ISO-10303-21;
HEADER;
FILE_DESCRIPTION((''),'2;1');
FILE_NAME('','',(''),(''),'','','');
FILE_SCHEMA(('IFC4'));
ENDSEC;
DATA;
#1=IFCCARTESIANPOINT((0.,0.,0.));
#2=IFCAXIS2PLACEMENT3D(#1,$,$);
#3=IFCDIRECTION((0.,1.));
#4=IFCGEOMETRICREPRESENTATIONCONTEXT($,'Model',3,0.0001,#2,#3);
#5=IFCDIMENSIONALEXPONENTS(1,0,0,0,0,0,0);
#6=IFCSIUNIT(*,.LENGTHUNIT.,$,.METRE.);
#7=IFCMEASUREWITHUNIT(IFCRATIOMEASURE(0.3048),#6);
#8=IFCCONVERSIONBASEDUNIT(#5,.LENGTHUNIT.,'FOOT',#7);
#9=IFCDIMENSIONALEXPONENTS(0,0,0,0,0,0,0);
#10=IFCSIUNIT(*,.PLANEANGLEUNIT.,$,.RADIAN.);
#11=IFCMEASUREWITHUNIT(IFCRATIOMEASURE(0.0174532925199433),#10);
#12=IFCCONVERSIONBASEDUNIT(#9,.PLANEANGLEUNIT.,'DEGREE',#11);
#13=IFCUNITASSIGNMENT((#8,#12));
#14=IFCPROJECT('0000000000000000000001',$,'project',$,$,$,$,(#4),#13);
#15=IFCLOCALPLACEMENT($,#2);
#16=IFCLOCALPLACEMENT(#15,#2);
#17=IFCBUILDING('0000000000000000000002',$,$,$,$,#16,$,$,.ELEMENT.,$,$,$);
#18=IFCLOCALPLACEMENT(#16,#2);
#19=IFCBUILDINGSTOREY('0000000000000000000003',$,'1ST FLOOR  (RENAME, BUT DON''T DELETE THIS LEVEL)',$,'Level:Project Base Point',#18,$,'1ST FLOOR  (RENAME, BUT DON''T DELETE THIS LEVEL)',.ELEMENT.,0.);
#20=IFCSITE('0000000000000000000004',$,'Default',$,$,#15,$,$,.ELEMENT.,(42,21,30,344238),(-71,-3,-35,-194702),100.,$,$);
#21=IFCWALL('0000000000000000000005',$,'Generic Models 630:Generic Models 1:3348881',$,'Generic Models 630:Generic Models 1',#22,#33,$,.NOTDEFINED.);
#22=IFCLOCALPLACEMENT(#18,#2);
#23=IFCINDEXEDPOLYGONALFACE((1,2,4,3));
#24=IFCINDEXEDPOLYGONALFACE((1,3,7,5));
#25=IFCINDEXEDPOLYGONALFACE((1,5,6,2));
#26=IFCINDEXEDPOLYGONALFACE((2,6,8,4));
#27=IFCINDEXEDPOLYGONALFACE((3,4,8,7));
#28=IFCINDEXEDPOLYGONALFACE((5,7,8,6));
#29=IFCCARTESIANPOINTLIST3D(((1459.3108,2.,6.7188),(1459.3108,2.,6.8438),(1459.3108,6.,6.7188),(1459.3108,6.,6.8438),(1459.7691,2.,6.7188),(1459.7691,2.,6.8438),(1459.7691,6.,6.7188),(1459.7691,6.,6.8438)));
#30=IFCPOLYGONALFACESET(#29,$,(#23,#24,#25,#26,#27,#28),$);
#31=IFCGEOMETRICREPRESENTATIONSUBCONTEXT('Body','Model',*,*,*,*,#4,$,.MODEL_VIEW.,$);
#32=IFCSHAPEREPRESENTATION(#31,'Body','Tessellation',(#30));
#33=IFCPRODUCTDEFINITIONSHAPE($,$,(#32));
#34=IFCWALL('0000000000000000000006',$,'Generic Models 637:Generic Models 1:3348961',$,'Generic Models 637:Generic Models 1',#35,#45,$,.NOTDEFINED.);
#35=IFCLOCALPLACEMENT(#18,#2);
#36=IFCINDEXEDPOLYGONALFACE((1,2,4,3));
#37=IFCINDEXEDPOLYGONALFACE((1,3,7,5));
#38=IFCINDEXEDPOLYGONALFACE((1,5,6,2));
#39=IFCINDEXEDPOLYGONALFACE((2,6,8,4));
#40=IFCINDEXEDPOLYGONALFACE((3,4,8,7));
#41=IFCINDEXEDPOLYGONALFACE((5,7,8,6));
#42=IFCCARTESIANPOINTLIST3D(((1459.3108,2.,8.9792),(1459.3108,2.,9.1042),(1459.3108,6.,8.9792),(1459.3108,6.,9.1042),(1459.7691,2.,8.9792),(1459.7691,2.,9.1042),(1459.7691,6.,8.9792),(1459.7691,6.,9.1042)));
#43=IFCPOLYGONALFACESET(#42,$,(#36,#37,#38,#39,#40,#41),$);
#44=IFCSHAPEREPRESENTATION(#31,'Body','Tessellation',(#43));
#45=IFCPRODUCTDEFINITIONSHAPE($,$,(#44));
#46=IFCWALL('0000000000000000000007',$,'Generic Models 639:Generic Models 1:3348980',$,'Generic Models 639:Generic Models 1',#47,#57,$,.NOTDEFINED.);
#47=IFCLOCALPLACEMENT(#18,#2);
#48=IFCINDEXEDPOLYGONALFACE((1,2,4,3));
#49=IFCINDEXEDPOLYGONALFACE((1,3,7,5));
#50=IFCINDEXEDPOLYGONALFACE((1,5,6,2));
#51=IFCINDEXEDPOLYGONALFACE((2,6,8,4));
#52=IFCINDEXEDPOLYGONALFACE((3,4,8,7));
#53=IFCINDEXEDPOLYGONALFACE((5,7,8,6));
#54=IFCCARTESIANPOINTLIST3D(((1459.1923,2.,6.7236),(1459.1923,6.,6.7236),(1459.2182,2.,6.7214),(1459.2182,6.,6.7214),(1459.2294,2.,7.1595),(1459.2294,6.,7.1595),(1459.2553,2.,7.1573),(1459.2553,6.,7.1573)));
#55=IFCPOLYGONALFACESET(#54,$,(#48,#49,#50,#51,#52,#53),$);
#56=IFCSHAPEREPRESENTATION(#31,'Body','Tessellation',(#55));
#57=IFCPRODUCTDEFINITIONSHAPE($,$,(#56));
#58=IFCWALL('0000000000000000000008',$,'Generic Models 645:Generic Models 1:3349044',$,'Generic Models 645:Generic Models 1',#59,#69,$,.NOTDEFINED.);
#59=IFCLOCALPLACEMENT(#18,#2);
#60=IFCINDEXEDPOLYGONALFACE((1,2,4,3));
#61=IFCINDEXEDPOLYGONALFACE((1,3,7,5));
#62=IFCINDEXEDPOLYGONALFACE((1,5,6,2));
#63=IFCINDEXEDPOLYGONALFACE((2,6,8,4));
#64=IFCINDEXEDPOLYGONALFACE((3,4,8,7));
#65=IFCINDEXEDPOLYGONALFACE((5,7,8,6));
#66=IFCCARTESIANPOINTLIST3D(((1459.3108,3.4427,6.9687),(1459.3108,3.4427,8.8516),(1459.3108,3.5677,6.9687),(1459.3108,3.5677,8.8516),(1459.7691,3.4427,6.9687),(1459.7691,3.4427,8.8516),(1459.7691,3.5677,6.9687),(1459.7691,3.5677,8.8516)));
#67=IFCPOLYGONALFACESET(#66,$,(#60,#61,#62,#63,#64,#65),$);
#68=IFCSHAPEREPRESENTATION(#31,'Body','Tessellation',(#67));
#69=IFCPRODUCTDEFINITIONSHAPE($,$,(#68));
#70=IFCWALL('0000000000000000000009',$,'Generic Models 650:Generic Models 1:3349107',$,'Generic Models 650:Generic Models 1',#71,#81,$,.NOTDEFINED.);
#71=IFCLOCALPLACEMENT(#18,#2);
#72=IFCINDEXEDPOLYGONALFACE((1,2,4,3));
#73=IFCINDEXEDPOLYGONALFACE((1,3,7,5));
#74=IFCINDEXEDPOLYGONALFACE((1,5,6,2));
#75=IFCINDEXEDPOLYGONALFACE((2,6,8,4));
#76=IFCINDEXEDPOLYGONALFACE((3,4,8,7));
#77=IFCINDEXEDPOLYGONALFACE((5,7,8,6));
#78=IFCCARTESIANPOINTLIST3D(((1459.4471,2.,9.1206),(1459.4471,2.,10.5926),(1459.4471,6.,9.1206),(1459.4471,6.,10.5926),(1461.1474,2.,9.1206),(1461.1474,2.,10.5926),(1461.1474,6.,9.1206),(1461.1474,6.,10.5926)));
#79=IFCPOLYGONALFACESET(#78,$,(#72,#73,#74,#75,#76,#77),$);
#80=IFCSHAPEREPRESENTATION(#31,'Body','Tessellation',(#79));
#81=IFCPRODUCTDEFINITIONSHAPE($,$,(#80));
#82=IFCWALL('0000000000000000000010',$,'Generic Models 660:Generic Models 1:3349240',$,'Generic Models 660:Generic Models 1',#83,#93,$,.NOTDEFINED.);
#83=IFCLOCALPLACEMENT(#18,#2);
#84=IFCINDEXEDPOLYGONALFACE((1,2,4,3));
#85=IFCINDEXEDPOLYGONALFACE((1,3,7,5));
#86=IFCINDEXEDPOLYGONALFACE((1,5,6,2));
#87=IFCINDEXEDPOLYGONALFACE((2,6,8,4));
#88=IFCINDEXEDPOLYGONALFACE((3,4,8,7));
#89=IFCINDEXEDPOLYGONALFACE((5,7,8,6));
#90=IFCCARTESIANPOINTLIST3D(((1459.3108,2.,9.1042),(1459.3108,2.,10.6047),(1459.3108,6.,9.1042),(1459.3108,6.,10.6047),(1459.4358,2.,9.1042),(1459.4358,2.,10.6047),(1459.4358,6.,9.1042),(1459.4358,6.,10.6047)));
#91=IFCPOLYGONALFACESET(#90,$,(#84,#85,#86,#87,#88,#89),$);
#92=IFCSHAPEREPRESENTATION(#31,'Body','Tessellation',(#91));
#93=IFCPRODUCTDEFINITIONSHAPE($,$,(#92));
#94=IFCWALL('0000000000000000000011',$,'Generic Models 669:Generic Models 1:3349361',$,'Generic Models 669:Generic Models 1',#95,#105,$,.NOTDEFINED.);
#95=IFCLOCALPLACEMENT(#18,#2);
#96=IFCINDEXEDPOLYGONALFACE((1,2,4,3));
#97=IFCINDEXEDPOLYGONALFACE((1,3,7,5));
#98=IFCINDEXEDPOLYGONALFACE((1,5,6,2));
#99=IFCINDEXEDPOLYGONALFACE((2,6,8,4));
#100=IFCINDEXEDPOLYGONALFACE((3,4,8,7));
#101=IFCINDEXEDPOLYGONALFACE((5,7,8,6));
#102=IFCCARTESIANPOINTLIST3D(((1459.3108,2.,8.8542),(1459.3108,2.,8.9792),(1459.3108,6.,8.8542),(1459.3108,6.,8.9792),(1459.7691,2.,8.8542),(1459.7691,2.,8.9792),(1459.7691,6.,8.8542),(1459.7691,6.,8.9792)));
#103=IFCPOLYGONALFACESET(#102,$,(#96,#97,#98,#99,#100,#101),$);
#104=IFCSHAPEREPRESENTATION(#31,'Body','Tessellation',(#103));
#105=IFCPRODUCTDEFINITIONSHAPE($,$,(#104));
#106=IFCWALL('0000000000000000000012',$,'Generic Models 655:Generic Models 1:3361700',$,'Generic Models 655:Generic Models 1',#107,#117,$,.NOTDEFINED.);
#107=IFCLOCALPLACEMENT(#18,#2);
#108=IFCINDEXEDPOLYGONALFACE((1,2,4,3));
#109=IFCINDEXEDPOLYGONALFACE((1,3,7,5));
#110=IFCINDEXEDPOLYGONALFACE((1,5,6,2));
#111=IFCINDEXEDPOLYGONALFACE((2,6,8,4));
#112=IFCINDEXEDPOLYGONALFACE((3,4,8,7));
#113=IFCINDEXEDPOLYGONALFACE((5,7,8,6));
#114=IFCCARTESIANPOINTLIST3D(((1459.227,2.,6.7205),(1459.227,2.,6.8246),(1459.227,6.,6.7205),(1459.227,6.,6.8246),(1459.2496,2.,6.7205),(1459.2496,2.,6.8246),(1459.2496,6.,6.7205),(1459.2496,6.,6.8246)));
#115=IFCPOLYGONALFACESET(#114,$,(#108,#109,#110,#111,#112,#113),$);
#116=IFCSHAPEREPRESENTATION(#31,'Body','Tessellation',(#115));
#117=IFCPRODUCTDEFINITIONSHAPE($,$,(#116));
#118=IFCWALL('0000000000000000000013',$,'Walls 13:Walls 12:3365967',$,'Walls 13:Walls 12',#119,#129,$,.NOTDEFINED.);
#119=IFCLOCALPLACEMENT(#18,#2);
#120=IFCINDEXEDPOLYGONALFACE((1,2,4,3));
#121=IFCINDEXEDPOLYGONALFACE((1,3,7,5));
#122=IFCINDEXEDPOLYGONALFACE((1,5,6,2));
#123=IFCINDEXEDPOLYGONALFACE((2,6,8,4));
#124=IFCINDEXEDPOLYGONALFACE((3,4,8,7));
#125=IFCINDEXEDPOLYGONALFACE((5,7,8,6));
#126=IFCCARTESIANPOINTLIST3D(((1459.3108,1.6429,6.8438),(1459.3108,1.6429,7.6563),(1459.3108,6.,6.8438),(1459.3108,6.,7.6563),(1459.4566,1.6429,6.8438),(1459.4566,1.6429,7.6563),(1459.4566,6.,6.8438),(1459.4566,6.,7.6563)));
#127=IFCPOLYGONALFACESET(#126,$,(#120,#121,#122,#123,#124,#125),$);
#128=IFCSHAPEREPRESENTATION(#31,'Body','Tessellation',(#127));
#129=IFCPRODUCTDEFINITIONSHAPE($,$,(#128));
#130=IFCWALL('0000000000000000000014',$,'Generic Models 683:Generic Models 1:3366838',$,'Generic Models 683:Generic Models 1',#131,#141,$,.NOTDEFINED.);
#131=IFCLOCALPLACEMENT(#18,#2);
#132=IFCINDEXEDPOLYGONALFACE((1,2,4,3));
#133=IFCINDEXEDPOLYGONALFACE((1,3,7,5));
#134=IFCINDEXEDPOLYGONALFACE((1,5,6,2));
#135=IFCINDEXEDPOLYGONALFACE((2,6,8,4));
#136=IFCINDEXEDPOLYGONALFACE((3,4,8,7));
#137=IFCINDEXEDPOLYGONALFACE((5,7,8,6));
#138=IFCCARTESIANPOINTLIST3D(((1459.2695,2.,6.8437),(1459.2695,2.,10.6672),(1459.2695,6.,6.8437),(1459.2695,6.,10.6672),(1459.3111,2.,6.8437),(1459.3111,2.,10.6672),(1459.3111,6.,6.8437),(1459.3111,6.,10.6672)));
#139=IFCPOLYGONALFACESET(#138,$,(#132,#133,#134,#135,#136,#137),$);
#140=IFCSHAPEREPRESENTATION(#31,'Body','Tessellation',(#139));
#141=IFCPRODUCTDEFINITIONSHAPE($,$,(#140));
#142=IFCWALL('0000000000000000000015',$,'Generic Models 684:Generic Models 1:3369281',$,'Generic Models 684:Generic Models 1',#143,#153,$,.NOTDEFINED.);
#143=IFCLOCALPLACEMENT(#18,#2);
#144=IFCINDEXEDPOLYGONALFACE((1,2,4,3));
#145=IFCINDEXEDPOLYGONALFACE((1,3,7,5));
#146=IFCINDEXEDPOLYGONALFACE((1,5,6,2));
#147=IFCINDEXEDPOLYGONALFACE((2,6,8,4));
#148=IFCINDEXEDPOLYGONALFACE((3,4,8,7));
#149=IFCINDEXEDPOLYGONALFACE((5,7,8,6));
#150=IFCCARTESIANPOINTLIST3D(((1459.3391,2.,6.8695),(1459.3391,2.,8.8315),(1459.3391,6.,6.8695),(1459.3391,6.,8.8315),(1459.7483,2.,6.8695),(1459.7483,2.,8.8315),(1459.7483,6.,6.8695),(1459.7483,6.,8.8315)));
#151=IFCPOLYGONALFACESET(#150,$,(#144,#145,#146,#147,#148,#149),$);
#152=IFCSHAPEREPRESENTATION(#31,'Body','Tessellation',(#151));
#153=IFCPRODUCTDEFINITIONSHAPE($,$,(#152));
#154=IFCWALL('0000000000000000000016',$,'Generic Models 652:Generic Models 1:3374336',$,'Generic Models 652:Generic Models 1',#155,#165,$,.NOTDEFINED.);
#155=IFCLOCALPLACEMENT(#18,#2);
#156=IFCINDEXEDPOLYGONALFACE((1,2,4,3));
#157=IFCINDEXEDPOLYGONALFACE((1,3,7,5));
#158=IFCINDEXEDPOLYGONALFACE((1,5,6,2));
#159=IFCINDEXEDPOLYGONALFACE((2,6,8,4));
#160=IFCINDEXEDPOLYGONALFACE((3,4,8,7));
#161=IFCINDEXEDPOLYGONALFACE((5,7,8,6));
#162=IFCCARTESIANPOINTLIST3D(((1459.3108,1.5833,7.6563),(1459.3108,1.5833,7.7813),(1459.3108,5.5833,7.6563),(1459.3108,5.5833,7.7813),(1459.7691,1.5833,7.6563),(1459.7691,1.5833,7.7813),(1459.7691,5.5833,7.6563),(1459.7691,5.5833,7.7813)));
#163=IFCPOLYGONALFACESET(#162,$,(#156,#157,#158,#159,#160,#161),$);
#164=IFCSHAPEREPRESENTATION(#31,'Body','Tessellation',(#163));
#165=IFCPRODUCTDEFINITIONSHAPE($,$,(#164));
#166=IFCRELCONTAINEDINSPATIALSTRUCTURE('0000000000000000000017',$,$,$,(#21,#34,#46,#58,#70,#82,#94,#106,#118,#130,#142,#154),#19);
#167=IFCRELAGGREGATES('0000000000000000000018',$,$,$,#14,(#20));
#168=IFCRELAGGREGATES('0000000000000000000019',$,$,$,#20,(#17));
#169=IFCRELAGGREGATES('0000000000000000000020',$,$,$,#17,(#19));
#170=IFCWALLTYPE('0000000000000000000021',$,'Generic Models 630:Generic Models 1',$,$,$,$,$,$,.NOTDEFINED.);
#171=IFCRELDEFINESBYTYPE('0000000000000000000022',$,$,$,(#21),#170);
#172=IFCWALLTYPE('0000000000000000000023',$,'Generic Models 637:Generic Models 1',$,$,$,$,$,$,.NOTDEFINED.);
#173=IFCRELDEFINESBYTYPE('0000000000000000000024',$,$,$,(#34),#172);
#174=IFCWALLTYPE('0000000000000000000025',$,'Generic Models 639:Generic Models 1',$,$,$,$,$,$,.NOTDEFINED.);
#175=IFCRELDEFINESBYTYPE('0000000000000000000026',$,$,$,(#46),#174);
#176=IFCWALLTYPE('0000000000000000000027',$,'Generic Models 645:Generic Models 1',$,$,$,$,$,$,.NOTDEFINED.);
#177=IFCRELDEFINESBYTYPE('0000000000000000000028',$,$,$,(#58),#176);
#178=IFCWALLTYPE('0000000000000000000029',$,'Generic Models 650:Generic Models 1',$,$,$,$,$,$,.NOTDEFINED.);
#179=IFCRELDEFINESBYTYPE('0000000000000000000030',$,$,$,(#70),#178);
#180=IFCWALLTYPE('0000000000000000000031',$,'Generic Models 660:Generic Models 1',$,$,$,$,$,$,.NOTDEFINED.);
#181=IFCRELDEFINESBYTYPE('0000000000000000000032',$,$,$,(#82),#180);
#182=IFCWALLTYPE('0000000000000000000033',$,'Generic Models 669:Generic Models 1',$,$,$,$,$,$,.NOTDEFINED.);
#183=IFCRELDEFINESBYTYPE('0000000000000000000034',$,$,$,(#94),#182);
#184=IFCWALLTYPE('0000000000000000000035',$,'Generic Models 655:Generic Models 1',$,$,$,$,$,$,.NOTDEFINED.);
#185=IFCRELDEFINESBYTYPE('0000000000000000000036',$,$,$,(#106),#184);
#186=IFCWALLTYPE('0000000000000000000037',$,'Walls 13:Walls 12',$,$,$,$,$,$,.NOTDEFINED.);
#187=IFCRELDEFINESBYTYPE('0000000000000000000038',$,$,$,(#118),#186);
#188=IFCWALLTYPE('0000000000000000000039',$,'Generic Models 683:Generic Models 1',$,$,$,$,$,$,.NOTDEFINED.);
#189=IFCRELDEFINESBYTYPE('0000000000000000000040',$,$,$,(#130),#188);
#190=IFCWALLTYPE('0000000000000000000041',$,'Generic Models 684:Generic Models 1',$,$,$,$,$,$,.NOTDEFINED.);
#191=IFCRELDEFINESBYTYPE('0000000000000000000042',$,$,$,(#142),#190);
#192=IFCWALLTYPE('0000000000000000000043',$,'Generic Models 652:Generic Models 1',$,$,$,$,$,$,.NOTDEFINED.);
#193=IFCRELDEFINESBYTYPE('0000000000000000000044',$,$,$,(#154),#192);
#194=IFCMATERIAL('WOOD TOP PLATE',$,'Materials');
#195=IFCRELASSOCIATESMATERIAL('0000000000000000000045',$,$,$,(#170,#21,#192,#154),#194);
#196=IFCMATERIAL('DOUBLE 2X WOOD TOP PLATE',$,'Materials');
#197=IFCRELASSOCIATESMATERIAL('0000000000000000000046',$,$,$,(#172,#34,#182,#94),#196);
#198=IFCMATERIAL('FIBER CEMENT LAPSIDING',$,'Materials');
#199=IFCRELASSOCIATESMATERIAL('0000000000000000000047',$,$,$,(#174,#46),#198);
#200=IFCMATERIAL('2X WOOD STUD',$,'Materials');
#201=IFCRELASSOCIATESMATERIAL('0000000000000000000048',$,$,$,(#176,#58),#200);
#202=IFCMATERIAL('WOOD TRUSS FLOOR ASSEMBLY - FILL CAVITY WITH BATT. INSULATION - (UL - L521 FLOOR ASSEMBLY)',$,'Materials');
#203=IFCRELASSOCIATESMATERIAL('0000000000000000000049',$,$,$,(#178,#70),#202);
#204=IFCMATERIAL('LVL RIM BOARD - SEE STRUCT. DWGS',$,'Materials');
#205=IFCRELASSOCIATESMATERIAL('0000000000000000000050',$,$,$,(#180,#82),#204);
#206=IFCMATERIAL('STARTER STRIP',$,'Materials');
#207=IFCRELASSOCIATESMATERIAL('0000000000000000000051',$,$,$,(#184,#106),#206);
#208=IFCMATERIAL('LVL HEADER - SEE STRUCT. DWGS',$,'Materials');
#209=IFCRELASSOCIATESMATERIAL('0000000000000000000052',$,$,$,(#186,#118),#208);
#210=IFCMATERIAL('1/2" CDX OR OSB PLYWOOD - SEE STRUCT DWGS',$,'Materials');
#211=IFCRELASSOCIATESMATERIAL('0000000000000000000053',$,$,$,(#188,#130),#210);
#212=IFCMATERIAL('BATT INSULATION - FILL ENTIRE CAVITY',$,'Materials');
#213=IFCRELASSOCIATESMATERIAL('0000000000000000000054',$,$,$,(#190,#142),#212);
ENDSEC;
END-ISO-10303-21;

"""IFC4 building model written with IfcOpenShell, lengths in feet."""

from ifc_helpers import new_model, entity, si_unit, converted_unit, direction, frame, frame_2d, origin, place, context, subcontext, project, spatial, rectangle, extrude, material, type_object, element, save


model = new_model("IFC4")

# Units and contexts
model_context = context("Model", 3, precision=0.0001, world=origin(), true_north=direction((0.0, 1.0)))
body_context = subcontext(model_context, "Body", "Model", "MODEL_VIEW")
ifc_project = project(units=[converted_unit("LENGTHUNIT", "FOOT", entity("IfcRatioMeasure", 0.3048), si_unit("LENGTHUNIT", "METRE"), dimensions=[1, 0, 0, 0, 0, 0, 0]), converted_unit("PLANEANGLEUNIT", "DEGREE", entity("IfcRatioMeasure", 0.0174532925199433), si_unit("PLANEANGLEUNIT", "RADIAN"), dimensions=[0, 0, 0, 0, 0, 0, 0])], contexts=[model_context])

# Site, building, storey
site_placement = place(None, origin())
site = spatial("IfcSite", under=ifc_project, at=site_placement, Name="Default", CompositionType="ELEMENT", RefLatitude=(42, 21, 30, 344238), RefLongitude=(-71, -3, -35, -194702), RefElevation=100.0)
building_placement = place(site_placement, origin())
building = spatial("IfcBuilding", under=site, at=building_placement, CompositionType="ELEMENT")
storey_placement = place(building_placement, origin())
storey = spatial("IfcBuildingStorey", under=building, at=storey_placement, Name="1ST FLOOR  (RENAME, BUT DON'T DELETE THIS LEVEL)", ObjectType="Level:Project Base Point", LongName="1ST FLOOR  (RENAME, BUT DON'T DELETE THIS LEVEL)", CompositionType="ELEMENT", Elevation=0.0)

# Walls
ifc_material_1 = material(Name="WOOD TOP PLATE", Category="Materials")
wall_type_1 = type_object("IfcWallType", Name="Generic Models 630:Generic Models 1", PredefinedType="NOTDEFINED", material=ifc_material_1)
wall_1_placement = place(storey_placement, frame((1459.3108, 2.0, 6.7188), z_axis=(0.0, 0.0, 1.0), x_axis=(0.0, 1.0, 0.0)))
element("IfcWall", 1, at=wall_1_placement, inside=storey, type_object=wall_type_1, material=ifc_material_1, Name="Generic Models 630:Generic Models 1:3348881", ObjectType="Generic Models 630:Generic Models 1", PredefinedType="NOTDEFINED", context=body_context, shape_type="SweptSolid", body=[
    extrude(rectangle(XDim=4.0, YDim=0.4583, at=frame_2d((0.0, 0.0), x_axis=(1.0, 0.0))), frame((2.0, -0.2292, 0.0)), (0.0, 0.0, 1.0), 0.125),
])
ifc_material_2 = material(Name="DOUBLE 2X WOOD TOP PLATE", Category="Materials")
wall_type_2 = type_object("IfcWallType", Name="Generic Models 637:Generic Models 1", PredefinedType="NOTDEFINED", material=ifc_material_2)
wall_2_placement = place(storey_placement, frame((1459.3108, 2.0, 8.9792), z_axis=(0.0, 0.0, 1.0), x_axis=(0.0, 1.0, 0.0)))
element("IfcWall", 2, at=wall_2_placement, inside=storey, type_object=wall_type_2, material=ifc_material_2, Name="Generic Models 637:Generic Models 1:3348961", ObjectType="Generic Models 637:Generic Models 1", PredefinedType="NOTDEFINED", context=body_context, shape_type="SweptSolid", body=[
    extrude(rectangle(XDim=4.0, YDim=0.4583, at=frame_2d((0.0, 0.0), x_axis=(1.0, 0.0))), frame((2.0, -0.2292, 0.0)), (0.0, 0.0, 1.0), 0.125),
])
ifc_material_3 = material(Name="FIBER CEMENT LAPSIDING", Category="Materials")
wall_type_3 = type_object("IfcWallType", Name="Generic Models 639:Generic Models 1", PredefinedType="NOTDEFINED", material=ifc_material_3)
wall_3_placement = place(storey_placement, frame((1459.1923, 2.0, 6.7214), z_axis=(0.0, 0.0, 1.0), x_axis=(0.0, 1.0, 0.0)))
element("IfcWall", 3, at=wall_3_placement, inside=storey, type_object=wall_type_3, material=ifc_material_3, Name="Generic Models 639:Generic Models 1:3348980", ObjectType="Generic Models 639:Generic Models 1", PredefinedType="NOTDEFINED", context=body_context, shape_type="SweptSolid", body=[
    extrude(rectangle(XDim=0.026, YDim=4.0, at=frame_2d((0.0, 0.0), x_axis=(0.0, 1.0))), frame((2.0, -0.013, 0.0011), z_axis=(0.0, -0.0848, 0.996398), x_axis=(1.0, 0.0, 0.0)), (0.0, 0.0, 1.0), 0.4375),
])
ifc_material_4 = material(Name="2X WOOD STUD", Category="Materials")
wall_type_4 = type_object("IfcWallType", Name="Generic Models 645:Generic Models 1", PredefinedType="NOTDEFINED", material=ifc_material_4)
wall_4_placement = place(storey_placement, frame((1459.3108, 3.4427, 6.9687)))
element("IfcWall", 4, at=wall_4_placement, inside=storey, type_object=wall_type_4, material=ifc_material_4, Name="Generic Models 645:Generic Models 1:3349044", ObjectType="Generic Models 645:Generic Models 1", PredefinedType="NOTDEFINED", context=body_context, shape_type="SweptSolid", body=[
    extrude(rectangle(XDim=0.125, YDim=0.4583, at=frame_2d((0.0, 0.0), x_axis=(1.0, 0.0))), frame((0.2292, 0.0625, 0.0), z_axis=(0.0, 0.0, 1.0), x_axis=(0.0, 1.0, 0.0)), (0.0, 0.0, 1.0), 1.8828),
])
ifc_material_5 = material(Name="WOOD TRUSS FLOOR ASSEMBLY - FILL CAVITY WITH BATT. INSULATION - (UL - L521 FLOOR ASSEMBLY)", Category="Materials")
wall_type_5 = type_object("IfcWallType", Name="Generic Models 650:Generic Models 1", PredefinedType="NOTDEFINED", material=ifc_material_5)
wall_5_placement = place(storey_placement, frame((1459.4471, 2.0, 9.1206), z_axis=(0.0, 0.0, 1.0), x_axis=(0.0, 1.0, 0.0)))
element("IfcWall", 5, at=wall_5_placement, inside=storey, type_object=wall_type_5, material=ifc_material_5, Name="Generic Models 650:Generic Models 1:3349107", ObjectType="Generic Models 650:Generic Models 1", PredefinedType="NOTDEFINED", context=body_context, shape_type="SweptSolid", body=[
    extrude(rectangle(XDim=4.0, YDim=1.7003, at=frame_2d((0.0, 0.0), x_axis=(1.0, 0.0))), frame((2.0, -0.8501, 0.0)), (0.0, 0.0, 1.0), 1.4719),
])
ifc_material_6 = material(Name="LVL RIM BOARD - SEE STRUCT. DWGS", Category="Materials")
wall_type_6 = type_object("IfcWallType", Name="Generic Models 660:Generic Models 1", PredefinedType="NOTDEFINED", material=ifc_material_6)
wall_6_placement = place(storey_placement, frame((1459.3108, 2.0, 9.1042), z_axis=(0.0, 0.0, 1.0), x_axis=(0.0, 1.0, 0.0)))
element("IfcWall", 6, at=wall_6_placement, inside=storey, type_object=wall_type_6, material=ifc_material_6, Name="Generic Models 660:Generic Models 1:3349240", ObjectType="Generic Models 660:Generic Models 1", PredefinedType="NOTDEFINED", context=body_context, shape_type="SweptSolid", body=[
    extrude(rectangle(XDim=4.0, YDim=0.125, at=frame_2d((0.0, 0.0), x_axis=(1.0, 0.0))), frame((2.0, -0.0625, 0.0)), (0.0, 0.0, 1.0), 1.5005),
])
wall_type_7 = type_object("IfcWallType", Name="Generic Models 669:Generic Models 1", PredefinedType="NOTDEFINED", material=ifc_material_2)
wall_7_placement = place(storey_placement, frame((1459.3108, 2.0, 8.8542), z_axis=(0.0, 0.0, 1.0), x_axis=(0.0, 1.0, 0.0)))
element("IfcWall", 7, at=wall_7_placement, inside=storey, type_object=wall_type_7, material=ifc_material_2, Name="Generic Models 669:Generic Models 1:3349361", ObjectType="Generic Models 669:Generic Models 1", PredefinedType="NOTDEFINED", context=body_context, shape_type="SweptSolid", body=[
    extrude(rectangle(XDim=4.0, YDim=0.4583, at=frame_2d((0.0, 0.0), x_axis=(1.0, 0.0))), frame((2.0, -0.2292, 0.0)), (0.0, 0.0, 1.0), 0.125),
])
ifc_material_7 = material(Name="STARTER STRIP", Category="Materials")
wall_type_8 = type_object("IfcWallType", Name="Generic Models 655:Generic Models 1", PredefinedType="NOTDEFINED", material=ifc_material_7)
wall_8_placement = place(storey_placement, frame((1459.227, 2.0, 6.7205), z_axis=(0.0, 0.0, 1.0), x_axis=(0.0, 1.0, 0.0)))
element("IfcWall", 8, at=wall_8_placement, inside=storey, type_object=wall_type_8, material=ifc_material_7, Name="Generic Models 655:Generic Models 1:3361700", ObjectType="Generic Models 655:Generic Models 1", PredefinedType="NOTDEFINED", context=body_context, shape_type="SweptSolid", body=[
    extrude(rectangle(XDim=4.0, YDim=0.0227, at=frame_2d((0.0, 0.0), x_axis=(1.0, 0.0))), frame((2.0, -0.0113, 0.0)), (0.0, 0.0, 1.0), 0.1042),
])
ifc_material_8 = material(Name="LVL HEADER - SEE STRUCT. DWGS", Category="Materials")
wall_type_9 = type_object("IfcWallType", Name="Walls 13:Walls 12", PredefinedType="NOTDEFINED", material=ifc_material_8)
wall_9_placement = place(storey_placement, frame((1459.3108, 1.6429, 6.8438), z_axis=(0.0, 0.0, 1.0), x_axis=(0.0, 1.0, 0.0)))
element("IfcWall", 9, at=wall_9_placement, inside=storey, type_object=wall_type_9, material=ifc_material_8, Name="Walls 13:Walls 12:3365967", ObjectType="Walls 13:Walls 12", PredefinedType="NOTDEFINED", context=body_context, shape_type="SweptSolid", body=[
    extrude(rectangle(XDim=4.3571, YDim=0.1458, at=frame_2d((0.0, 0.0), x_axis=(1.0, 0.0))), frame((2.1785, -0.0729, 0.0)), (0.0, 0.0, 1.0), 0.8125),
])
ifc_material_9 = material(Name="1/2\" CDX OR OSB PLYWOOD - SEE STRUCT DWGS", Category="Materials")
wall_type_10 = type_object("IfcWallType", Name="Generic Models 683:Generic Models 1", PredefinedType="NOTDEFINED", material=ifc_material_9)
wall_10_placement = place(storey_placement, frame((1459.2695, 2.0, 6.8437), z_axis=(0.0, 0.0, 1.0), x_axis=(0.0, 1.0, 0.0)))
element("IfcWall", 10, at=wall_10_placement, inside=storey, type_object=wall_type_10, material=ifc_material_9, Name="Generic Models 683:Generic Models 1:3366838", ObjectType="Generic Models 683:Generic Models 1", PredefinedType="NOTDEFINED", context=body_context, shape_type="SweptSolid", body=[
    extrude(rectangle(XDim=4.0, YDim=0.0417, at=frame_2d((0.0, 0.0), x_axis=(1.0, 0.0))), frame((2.0, -0.0208, 0.0)), (0.0, 0.0, 1.0), 3.8235),
])
ifc_material_10 = material(Name="BATT INSULATION - FILL ENTIRE CAVITY", Category="Materials")
wall_type_11 = type_object("IfcWallType", Name="Generic Models 684:Generic Models 1", PredefinedType="NOTDEFINED", material=ifc_material_10)
wall_11_placement = place(storey_placement, frame((1459.3391, 2.0, 6.8695), z_axis=(0.0, 0.0, 1.0), x_axis=(0.0, 1.0, 0.0)))
element("IfcWall", 11, at=wall_11_placement, inside=storey, type_object=wall_type_11, material=ifc_material_10, Name="Generic Models 684:Generic Models 1:3369281", ObjectType="Generic Models 684:Generic Models 1", PredefinedType="NOTDEFINED", context=body_context, shape_type="SweptSolid", body=[
    extrude(rectangle(XDim=4.0, YDim=0.4092, at=frame_2d((0.0, 0.0), x_axis=(1.0, 0.0))), frame((2.0, -0.2046, 0.0)), (0.0, 0.0, 1.0), 1.962),
])
wall_type_12 = type_object("IfcWallType", Name="Generic Models 652:Generic Models 1", PredefinedType="NOTDEFINED", material=ifc_material_1)
wall_12_placement = place(storey_placement, frame((1459.3108, 1.5833, 7.6563), z_axis=(0.0, 0.0, 1.0), x_axis=(0.0, 1.0, 0.0)))
element("IfcWall", 12, at=wall_12_placement, inside=storey, type_object=wall_type_12, material=ifc_material_1, Name="Generic Models 652:Generic Models 1:3374336", ObjectType="Generic Models 652:Generic Models 1", PredefinedType="NOTDEFINED", context=body_context, shape_type="SweptSolid", body=[
    extrude(rectangle(XDim=4.0, YDim=0.4583, at=frame_2d((0.0, 0.0), x_axis=(1.0, 0.0))), frame((2.0, -0.2292, 0.0)), (0.0, 0.0, 1.0), 0.125),
])

save(model, "model.ifc")
